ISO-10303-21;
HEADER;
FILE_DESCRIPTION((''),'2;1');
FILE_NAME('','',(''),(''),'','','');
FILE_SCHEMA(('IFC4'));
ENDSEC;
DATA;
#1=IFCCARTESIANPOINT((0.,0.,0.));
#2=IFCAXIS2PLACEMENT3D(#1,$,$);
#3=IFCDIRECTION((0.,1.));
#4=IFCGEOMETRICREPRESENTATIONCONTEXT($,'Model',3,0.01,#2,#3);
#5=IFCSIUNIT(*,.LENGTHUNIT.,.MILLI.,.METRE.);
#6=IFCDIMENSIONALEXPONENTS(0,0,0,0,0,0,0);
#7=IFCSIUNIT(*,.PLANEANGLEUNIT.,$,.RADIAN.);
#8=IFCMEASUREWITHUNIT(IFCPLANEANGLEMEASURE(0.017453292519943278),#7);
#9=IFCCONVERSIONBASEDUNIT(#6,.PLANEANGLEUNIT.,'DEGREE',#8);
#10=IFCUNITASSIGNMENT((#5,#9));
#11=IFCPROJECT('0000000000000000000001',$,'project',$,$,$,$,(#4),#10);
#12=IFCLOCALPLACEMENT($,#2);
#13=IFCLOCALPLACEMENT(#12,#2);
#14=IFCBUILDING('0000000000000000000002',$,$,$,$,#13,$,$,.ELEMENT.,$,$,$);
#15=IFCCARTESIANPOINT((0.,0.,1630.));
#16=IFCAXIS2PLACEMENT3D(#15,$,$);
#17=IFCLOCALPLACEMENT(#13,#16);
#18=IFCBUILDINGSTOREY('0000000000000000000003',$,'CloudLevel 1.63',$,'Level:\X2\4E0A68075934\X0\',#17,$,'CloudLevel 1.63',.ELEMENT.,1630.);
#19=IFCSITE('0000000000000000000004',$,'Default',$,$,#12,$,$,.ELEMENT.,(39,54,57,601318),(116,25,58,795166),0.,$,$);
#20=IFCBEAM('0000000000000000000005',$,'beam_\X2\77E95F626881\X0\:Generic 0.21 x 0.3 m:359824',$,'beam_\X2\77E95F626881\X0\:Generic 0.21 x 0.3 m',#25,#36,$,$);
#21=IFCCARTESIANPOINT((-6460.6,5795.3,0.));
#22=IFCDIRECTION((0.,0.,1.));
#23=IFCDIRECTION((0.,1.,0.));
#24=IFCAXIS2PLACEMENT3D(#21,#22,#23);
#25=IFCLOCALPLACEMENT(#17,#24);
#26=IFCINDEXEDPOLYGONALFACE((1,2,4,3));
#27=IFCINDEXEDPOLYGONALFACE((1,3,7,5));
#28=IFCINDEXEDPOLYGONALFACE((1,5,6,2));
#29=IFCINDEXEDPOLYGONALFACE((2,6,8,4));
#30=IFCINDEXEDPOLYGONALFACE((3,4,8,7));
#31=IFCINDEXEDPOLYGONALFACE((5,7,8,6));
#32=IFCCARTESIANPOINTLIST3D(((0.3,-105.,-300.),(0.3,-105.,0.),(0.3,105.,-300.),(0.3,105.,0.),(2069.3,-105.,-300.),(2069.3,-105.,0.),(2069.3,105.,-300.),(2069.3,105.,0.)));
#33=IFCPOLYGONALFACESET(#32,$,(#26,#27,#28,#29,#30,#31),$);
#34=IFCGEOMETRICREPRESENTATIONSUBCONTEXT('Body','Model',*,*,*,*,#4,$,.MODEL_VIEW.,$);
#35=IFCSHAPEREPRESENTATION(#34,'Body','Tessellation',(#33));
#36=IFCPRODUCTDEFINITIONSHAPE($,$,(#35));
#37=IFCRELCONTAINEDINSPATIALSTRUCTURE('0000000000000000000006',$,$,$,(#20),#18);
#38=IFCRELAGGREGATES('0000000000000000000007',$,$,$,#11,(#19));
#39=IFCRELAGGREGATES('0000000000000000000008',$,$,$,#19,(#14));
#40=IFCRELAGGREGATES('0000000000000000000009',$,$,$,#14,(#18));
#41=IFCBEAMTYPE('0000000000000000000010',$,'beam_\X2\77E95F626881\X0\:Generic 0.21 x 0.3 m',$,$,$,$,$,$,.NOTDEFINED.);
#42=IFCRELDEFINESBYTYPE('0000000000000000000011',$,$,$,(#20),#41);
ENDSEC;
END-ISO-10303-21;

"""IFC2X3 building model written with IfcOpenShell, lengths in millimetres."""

from ifc_helpers import new_model, entity, si_unit, converted_unit, direction, frame, frame_2d, origin, place, context, subcontext, project, spatial, rectangle, extrude, type_object, element, save


model = new_model("IFC2X3")

# Units and contexts
model_context = context("Model", 3, precision=0.01, world=origin(), true_north=direction((0.0, 1.0)))
body_context = subcontext(model_context, "Body", "Model", "MODEL_VIEW")
ifc_project = project(units=[si_unit("LENGTHUNIT", "METRE", prefix="MILLI"), converted_unit("PLANEANGLEUNIT", "DEGREE", entity("IfcPlaneAngleMeasure", 0.017453292519943278), si_unit("PLANEANGLEUNIT", "RADIAN"), dimensions=[0, 0, 0, 0, 0, 0, 0])], contexts=[model_context])

# Site, building, storey
site_placement = place(None, origin())
site = spatial("IfcSite", under=ifc_project, at=site_placement, Name="Default", CompositionType="ELEMENT", RefLatitude=(39, 54, 57, 601318), RefLongitude=(116, 25, 58, 795166), RefElevation=0.0)
building_placement = place(site_placement, origin())
building = spatial("IfcBuilding", under=site, at=building_placement, CompositionType="ELEMENT")
storey_placement = place(building_placement, frame((0.0, 0.0, 1630.0)))
storey = spatial("IfcBuildingStorey", under=building, at=storey_placement, Name="CloudLevel 1.63", ObjectType="Level:上标头", LongName="CloudLevel 1.63", CompositionType="ELEMENT", Elevation=1630.0)

# Beam
beam_type_1 = type_object("IfcBeamType", Name="beam_矩形梁:Generic 0.21 x 0.3 m", PredefinedType="NOTDEFINED")
beam_1_placement = place(storey_placement, frame((-6460.6, 5795.3, 0.0), z_axis=(0.0, 0.0, 1.0), x_axis=(0.0, 1.0, 0.0)))
element("IfcBeam", 1, at=beam_1_placement, inside=storey, type_object=beam_type_1, Name="beam_矩形梁:Generic 0.21 x 0.3 m:359824", ObjectType="beam_矩形梁:Generic 0.21 x 0.3 m", context=body_context, shape_type="SweptSolid", body=[
    extrude(rectangle(XDim=300.0, YDim=210.0, at=frame_2d((0.0, 0.0), x_axis=(1.0, 0.0))), frame((0.3, 0.0, -150.0), z_axis=(1.0, 0.0, 0.0), x_axis=(0.0, 0.0, -1.0)), (0.0, 0.0, 1.0), 2069.0),
])

save(model, "model.ifc")
